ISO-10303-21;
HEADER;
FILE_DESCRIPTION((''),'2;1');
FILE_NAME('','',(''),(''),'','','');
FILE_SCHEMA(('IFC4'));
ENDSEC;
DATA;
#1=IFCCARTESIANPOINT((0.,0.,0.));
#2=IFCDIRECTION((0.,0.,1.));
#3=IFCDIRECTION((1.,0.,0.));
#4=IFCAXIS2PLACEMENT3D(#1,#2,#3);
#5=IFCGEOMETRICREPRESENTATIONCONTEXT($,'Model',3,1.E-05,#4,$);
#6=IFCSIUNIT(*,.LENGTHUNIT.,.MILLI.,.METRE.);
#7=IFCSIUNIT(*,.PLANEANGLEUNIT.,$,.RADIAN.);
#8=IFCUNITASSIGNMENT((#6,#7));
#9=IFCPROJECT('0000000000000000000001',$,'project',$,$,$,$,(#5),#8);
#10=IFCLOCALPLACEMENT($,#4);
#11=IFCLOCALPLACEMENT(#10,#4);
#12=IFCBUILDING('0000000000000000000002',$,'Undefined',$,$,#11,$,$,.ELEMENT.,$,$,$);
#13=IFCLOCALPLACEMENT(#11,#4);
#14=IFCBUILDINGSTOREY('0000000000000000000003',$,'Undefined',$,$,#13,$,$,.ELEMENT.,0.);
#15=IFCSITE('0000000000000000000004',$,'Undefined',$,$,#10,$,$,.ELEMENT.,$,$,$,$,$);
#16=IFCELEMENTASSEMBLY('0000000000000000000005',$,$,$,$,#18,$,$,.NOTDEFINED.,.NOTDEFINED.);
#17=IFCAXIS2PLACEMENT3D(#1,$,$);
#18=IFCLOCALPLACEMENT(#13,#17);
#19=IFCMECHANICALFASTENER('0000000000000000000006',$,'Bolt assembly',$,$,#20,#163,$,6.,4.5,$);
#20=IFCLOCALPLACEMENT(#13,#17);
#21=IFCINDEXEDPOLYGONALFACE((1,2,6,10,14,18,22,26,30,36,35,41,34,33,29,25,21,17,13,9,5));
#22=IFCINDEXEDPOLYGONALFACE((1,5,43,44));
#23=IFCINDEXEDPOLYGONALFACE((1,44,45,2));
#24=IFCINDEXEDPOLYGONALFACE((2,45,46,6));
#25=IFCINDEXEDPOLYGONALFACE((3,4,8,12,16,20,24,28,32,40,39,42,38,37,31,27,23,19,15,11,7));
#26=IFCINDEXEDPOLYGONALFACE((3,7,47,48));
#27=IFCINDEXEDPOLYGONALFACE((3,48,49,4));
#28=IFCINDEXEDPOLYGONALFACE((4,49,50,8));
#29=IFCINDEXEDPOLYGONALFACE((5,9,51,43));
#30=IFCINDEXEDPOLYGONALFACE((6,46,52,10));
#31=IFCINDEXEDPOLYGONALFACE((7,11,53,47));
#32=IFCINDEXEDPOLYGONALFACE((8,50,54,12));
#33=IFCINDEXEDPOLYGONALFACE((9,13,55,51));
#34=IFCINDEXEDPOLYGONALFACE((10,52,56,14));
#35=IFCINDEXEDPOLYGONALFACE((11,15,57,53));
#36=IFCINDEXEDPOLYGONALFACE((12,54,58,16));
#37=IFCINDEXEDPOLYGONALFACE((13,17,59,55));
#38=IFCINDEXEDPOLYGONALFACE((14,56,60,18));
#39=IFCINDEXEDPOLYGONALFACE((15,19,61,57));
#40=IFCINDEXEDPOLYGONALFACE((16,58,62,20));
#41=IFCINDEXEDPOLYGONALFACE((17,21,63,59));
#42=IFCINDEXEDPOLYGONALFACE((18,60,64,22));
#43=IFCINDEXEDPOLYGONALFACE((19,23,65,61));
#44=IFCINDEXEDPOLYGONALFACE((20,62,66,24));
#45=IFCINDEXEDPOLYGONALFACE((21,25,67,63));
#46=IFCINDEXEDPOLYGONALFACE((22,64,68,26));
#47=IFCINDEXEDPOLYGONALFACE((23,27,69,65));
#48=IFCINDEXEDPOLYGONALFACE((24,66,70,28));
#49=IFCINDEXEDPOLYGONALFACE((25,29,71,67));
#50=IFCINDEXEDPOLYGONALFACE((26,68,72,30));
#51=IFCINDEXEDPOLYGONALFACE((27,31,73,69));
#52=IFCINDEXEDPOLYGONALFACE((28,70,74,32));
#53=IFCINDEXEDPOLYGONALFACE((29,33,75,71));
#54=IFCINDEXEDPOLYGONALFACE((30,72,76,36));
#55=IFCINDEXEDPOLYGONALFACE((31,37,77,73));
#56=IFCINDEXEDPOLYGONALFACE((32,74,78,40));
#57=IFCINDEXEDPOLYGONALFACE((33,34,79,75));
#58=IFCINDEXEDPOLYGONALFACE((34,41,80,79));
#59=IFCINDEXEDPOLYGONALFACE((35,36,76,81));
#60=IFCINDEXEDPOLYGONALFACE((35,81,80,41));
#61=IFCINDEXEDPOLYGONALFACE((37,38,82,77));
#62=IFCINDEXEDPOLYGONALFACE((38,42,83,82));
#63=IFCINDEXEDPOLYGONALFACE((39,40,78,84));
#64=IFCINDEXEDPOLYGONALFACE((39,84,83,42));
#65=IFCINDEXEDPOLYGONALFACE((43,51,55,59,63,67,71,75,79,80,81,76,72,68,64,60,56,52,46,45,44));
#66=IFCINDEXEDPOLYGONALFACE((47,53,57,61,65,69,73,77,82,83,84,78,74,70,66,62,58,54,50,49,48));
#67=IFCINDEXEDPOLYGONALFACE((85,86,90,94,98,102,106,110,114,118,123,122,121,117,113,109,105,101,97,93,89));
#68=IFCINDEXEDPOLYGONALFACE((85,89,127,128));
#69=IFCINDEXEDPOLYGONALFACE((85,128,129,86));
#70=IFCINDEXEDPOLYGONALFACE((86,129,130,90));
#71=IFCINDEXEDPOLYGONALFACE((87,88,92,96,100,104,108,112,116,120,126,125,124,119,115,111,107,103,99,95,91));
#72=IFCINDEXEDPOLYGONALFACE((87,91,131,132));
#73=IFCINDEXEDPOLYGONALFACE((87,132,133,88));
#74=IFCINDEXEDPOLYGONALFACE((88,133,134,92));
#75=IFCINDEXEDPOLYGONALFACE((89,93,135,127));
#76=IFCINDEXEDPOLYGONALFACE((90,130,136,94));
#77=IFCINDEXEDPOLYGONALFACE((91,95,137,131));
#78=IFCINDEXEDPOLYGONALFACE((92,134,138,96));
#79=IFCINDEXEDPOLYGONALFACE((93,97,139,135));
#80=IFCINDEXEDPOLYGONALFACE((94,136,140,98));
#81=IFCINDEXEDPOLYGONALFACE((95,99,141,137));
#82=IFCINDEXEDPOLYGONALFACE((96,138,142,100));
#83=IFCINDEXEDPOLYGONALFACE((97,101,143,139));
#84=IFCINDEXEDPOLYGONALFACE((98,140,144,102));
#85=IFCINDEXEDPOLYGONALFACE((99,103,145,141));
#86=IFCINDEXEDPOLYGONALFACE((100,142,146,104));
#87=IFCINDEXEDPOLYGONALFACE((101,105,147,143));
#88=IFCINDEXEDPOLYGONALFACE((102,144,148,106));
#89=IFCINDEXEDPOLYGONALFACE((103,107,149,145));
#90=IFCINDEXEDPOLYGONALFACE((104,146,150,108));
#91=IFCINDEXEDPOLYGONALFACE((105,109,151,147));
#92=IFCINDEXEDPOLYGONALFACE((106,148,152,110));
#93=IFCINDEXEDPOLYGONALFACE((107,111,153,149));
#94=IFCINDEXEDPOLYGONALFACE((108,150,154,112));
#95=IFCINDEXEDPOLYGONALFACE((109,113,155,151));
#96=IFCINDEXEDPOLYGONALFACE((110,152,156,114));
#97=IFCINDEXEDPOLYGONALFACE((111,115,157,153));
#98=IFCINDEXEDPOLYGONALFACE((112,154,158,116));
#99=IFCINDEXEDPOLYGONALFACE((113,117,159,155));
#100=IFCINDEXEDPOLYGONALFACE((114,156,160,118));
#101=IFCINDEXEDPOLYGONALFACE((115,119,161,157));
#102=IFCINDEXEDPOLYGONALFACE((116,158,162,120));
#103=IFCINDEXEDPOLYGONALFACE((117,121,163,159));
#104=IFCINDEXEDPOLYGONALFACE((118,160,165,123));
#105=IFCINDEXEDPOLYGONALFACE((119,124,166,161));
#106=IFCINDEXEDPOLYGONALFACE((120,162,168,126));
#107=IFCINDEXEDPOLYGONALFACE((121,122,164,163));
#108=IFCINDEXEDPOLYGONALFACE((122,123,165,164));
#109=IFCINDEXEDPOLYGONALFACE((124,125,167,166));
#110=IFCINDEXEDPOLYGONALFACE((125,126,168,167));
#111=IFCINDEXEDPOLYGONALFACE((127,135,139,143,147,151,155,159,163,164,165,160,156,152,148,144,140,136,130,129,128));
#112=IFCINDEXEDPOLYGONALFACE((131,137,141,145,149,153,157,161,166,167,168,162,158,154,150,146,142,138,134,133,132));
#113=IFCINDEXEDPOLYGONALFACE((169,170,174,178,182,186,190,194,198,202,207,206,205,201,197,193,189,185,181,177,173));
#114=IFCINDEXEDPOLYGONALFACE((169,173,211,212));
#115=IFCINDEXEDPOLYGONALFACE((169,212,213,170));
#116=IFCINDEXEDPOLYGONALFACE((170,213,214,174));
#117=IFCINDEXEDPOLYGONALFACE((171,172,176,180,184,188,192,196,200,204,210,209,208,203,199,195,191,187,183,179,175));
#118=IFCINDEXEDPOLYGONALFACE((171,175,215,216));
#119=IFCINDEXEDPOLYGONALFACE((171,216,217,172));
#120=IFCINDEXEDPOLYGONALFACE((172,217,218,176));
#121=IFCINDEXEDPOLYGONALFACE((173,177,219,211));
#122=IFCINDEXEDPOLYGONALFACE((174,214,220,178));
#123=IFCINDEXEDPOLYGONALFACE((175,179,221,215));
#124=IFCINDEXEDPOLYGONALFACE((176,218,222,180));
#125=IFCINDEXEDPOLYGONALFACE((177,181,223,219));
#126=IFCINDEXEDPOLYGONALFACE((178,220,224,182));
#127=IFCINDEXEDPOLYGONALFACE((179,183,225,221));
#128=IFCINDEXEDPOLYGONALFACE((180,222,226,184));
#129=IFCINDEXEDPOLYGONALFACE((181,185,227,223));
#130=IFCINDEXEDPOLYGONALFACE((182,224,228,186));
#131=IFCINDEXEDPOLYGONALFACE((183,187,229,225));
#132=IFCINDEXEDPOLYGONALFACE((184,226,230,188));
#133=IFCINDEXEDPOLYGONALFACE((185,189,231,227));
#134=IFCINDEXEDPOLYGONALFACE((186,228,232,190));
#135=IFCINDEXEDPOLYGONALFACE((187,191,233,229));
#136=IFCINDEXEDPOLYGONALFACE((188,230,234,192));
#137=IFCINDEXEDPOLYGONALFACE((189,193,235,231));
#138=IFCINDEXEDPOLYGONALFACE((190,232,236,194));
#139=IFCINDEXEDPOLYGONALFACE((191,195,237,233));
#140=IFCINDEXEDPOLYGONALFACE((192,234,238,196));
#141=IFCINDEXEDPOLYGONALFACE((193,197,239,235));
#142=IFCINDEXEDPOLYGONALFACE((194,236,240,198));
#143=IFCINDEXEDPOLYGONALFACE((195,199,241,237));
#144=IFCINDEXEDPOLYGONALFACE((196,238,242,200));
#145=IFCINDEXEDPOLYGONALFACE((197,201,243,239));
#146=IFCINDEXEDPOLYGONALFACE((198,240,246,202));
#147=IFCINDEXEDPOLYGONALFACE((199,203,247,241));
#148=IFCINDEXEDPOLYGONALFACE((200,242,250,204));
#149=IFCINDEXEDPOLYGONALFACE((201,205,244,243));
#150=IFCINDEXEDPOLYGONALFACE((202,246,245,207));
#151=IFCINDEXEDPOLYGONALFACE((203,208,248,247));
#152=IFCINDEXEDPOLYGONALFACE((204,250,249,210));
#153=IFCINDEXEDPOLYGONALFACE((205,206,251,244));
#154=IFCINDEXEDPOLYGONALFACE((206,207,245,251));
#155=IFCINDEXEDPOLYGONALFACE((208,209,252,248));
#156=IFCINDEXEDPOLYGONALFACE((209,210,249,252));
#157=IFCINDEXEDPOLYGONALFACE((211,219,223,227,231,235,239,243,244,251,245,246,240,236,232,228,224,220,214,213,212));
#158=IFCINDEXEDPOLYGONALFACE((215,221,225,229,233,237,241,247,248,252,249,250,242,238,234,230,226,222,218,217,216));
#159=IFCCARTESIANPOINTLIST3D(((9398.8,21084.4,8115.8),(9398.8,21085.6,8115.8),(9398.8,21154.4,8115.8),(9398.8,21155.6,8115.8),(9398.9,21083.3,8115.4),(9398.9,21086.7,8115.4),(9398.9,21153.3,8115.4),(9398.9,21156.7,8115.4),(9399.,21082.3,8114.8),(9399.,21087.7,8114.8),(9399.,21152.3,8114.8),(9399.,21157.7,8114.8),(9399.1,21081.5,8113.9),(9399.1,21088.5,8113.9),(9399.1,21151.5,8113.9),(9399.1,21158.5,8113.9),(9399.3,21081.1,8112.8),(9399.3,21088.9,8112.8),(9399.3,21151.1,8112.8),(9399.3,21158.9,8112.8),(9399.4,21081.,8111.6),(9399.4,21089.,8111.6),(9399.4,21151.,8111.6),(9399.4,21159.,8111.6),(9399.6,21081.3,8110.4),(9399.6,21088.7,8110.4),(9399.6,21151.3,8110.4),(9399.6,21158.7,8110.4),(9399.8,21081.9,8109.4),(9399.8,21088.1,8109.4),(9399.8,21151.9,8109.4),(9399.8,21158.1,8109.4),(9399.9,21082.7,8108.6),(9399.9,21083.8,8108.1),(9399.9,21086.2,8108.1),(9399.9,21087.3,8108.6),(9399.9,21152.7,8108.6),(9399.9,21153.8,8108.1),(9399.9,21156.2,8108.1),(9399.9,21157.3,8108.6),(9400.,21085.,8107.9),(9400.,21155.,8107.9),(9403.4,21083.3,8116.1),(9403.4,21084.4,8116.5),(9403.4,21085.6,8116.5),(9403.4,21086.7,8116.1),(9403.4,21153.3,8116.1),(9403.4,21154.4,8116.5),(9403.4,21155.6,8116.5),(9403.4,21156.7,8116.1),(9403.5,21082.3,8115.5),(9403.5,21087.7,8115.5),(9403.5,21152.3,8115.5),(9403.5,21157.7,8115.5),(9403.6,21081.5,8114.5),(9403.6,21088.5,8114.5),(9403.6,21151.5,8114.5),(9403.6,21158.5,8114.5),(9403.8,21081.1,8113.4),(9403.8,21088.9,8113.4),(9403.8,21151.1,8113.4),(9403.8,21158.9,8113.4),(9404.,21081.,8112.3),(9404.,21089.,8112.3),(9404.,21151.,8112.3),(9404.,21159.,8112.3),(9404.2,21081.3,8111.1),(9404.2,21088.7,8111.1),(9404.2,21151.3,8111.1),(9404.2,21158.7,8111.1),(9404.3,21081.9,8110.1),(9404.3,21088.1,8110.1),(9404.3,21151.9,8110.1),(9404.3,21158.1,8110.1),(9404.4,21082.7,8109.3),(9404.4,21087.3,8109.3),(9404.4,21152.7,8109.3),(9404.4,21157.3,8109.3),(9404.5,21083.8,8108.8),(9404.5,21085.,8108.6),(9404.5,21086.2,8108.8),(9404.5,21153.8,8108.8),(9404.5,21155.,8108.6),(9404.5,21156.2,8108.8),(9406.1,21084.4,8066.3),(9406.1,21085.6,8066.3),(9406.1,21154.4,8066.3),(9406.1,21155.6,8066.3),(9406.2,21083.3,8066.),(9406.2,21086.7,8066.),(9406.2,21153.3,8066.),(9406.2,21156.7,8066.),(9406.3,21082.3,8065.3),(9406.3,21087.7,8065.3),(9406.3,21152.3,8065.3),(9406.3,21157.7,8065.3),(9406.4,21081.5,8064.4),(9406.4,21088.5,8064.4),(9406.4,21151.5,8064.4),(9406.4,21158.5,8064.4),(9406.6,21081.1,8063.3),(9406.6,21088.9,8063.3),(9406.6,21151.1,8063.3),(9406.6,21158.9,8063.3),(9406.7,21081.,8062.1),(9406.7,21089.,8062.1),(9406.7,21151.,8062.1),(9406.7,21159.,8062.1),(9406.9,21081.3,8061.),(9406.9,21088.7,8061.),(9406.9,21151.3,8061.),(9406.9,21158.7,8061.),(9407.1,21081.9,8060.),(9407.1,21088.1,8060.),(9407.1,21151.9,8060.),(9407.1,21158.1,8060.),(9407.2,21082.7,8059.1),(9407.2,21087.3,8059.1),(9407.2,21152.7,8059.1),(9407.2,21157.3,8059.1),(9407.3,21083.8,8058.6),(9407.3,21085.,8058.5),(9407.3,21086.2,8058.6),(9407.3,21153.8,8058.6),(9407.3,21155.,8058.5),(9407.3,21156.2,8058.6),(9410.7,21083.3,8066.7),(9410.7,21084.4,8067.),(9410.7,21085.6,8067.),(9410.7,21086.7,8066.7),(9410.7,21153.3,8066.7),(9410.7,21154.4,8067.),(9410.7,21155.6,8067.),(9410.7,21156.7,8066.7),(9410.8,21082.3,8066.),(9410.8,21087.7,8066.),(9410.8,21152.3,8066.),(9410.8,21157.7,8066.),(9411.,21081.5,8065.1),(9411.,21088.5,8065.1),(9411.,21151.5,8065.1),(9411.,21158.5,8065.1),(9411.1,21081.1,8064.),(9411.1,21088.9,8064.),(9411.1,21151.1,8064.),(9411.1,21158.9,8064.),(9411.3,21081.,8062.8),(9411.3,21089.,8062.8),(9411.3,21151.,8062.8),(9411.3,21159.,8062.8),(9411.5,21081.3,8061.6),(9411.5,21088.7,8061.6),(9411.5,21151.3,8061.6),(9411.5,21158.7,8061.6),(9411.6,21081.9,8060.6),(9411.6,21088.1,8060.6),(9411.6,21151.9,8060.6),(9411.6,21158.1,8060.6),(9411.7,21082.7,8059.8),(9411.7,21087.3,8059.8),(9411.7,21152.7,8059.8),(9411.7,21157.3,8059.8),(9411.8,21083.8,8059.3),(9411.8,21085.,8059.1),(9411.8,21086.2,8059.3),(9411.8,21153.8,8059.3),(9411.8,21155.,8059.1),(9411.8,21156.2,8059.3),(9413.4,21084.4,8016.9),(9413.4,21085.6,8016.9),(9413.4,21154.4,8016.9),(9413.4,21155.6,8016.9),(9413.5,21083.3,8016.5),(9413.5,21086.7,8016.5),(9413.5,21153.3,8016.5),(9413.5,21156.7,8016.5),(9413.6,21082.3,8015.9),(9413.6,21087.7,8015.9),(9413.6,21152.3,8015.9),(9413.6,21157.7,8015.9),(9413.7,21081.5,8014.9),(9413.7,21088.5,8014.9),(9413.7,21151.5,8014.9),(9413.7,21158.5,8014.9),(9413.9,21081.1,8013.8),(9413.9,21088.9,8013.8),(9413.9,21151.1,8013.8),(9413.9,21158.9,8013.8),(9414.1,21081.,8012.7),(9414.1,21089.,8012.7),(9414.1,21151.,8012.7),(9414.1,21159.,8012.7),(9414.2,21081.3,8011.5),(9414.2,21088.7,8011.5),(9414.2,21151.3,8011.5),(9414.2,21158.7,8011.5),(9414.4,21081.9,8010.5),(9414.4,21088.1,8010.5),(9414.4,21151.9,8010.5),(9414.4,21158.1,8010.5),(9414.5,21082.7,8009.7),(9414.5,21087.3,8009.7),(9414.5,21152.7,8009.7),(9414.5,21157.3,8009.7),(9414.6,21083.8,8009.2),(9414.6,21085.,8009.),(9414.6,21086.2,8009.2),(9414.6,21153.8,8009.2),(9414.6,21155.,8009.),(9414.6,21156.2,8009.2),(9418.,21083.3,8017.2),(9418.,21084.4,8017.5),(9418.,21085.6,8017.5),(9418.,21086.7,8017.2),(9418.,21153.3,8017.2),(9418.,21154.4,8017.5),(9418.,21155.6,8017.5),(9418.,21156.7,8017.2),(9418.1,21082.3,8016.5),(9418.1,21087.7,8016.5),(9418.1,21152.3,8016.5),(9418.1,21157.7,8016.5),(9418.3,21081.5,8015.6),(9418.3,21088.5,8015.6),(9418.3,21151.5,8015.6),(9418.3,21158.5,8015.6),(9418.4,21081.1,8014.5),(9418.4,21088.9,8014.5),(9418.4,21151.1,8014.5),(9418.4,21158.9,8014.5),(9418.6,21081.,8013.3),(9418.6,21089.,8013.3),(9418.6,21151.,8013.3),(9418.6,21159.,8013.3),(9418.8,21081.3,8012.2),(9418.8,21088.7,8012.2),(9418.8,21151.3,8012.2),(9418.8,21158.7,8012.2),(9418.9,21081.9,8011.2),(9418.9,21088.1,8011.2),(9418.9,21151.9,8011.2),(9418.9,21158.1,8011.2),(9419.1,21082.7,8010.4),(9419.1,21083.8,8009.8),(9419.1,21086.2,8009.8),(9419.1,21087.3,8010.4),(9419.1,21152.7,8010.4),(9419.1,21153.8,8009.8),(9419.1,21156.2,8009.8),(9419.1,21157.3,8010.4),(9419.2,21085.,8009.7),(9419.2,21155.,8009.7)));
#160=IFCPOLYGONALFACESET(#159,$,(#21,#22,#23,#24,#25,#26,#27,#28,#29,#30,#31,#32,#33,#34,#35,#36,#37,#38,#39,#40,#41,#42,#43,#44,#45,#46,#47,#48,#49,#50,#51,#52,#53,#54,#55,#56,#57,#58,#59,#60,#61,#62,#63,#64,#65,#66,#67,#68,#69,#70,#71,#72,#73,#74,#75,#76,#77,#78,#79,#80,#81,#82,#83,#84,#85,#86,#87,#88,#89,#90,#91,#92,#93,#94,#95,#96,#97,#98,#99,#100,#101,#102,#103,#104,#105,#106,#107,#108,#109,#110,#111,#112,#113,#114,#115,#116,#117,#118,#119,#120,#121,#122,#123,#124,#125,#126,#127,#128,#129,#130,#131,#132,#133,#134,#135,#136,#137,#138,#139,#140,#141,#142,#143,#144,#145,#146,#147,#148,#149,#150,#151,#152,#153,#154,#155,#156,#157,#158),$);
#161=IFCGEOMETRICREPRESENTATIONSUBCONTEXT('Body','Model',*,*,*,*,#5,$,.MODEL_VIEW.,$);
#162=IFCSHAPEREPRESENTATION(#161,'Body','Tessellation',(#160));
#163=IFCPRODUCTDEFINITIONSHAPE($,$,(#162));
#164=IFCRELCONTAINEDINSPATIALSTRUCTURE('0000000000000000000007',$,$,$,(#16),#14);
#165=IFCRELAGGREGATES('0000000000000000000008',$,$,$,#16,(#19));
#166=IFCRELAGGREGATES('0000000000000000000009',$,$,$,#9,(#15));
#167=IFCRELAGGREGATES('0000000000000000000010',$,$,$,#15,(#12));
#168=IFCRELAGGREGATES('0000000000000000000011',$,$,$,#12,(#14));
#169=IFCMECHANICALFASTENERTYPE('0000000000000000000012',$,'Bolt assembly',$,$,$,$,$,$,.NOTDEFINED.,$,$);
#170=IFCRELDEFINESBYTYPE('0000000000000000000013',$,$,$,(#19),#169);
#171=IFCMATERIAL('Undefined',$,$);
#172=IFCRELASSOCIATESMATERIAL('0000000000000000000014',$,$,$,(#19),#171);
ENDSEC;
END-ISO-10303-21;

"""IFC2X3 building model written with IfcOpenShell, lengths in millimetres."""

from ifc_helpers import new_model, si_unit, frame, origin_with_axes, origin_2d_with_axis, place, context, subcontext, project, spatial, circle, extrude, source, transform, mapped, material, type_object, element, aggregate, save


model = new_model("IFC2X3")

# Units and contexts
model_context = context("Model", 3, precision=1e-05, world=origin_with_axes())
body_context = subcontext(model_context, "Body", "Model", "MODEL_VIEW")
ifc_project = project(units=[si_unit("LENGTHUNIT", "METRE", prefix="MILLI"), si_unit("PLANEANGLEUNIT", "RADIAN")], contexts=[model_context])

# Site, building, storey
site_placement = place(None, origin_with_axes())
site = spatial("IfcSite", under=ifc_project, at=site_placement, Name="Undefined", CompositionType="ELEMENT")
building_placement = place(site_placement, origin_with_axes())
building = spatial("IfcBuilding", under=site, at=building_placement, Name="Undefined", CompositionType="ELEMENT")
storey_placement = place(building_placement, origin_with_axes())
storey = spatial("IfcBuildingStorey", under=building, at=storey_placement, Name="Undefined", CompositionType="ELEMENT", Elevation=0.0)

# Element assembly
assembly_1_placement = place(storey_placement, origin_with_axes())
assembly_1 = element("IfcElementAssembly", 1, at=assembly_1_placement, inside=storey, AssemblyPlace="NOTDEFINED", PredefinedType="NOTDEFINED")

# Mechanical fastener
ifc_material_1 = material(Name="Undefined")
mechanical_fastener_type = type_object("IfcMechanicalFastenerType", Name="Bolt assembly")
shared_shape_1 = source(origin_with_axes(), body_context, "Body", "SweptSolid", [
    extrude(circle(Radius=4.0, at=origin_2d_with_axis()), frame((0.0, 0.0, 0.0), z_axis=(0.0, 1.0, 0.0), x_axis=(1.0, 0.0, 0.0)), (0.0, 0.0, 1.0), 4.6),
])
mechanical_fastener_1_placement = place(assembly_1_placement, frame((9403.9, 21120.0, 8112.6), z_axis=(0.0, 1.0, 0.0), x_axis=(0.14631, 0.0, -0.989239)))
mechanical_fastener_1 = element("IfcMechanicalFastener", 2, at=mechanical_fastener_1_placement, type_object=mechanical_fastener_type, material=ifc_material_1, Name="Bolt assembly", NominalDiameter=6.0, NominalLength=4.5, context=body_context, shape_type="MappedRepresentation", body=[
    mapped(shared_shape_1, transform((0.0, 0.0, 35.0))),
    mapped(shared_shape_1, transform((50.0, 0.0, 35.0))),
    mapped(shared_shape_1, transform((100.0, 0.0, 35.0))),
    mapped(shared_shape_1, transform((0.0, 0.0, -35.0))),
    mapped(shared_shape_1, transform((50.0, 0.0, -35.0))),
    mapped(shared_shape_1, transform((100.0, 0.0, -35.0))),
])

aggregate(assembly_1, [mechanical_fastener_1])

save(model, "model.ifc")
